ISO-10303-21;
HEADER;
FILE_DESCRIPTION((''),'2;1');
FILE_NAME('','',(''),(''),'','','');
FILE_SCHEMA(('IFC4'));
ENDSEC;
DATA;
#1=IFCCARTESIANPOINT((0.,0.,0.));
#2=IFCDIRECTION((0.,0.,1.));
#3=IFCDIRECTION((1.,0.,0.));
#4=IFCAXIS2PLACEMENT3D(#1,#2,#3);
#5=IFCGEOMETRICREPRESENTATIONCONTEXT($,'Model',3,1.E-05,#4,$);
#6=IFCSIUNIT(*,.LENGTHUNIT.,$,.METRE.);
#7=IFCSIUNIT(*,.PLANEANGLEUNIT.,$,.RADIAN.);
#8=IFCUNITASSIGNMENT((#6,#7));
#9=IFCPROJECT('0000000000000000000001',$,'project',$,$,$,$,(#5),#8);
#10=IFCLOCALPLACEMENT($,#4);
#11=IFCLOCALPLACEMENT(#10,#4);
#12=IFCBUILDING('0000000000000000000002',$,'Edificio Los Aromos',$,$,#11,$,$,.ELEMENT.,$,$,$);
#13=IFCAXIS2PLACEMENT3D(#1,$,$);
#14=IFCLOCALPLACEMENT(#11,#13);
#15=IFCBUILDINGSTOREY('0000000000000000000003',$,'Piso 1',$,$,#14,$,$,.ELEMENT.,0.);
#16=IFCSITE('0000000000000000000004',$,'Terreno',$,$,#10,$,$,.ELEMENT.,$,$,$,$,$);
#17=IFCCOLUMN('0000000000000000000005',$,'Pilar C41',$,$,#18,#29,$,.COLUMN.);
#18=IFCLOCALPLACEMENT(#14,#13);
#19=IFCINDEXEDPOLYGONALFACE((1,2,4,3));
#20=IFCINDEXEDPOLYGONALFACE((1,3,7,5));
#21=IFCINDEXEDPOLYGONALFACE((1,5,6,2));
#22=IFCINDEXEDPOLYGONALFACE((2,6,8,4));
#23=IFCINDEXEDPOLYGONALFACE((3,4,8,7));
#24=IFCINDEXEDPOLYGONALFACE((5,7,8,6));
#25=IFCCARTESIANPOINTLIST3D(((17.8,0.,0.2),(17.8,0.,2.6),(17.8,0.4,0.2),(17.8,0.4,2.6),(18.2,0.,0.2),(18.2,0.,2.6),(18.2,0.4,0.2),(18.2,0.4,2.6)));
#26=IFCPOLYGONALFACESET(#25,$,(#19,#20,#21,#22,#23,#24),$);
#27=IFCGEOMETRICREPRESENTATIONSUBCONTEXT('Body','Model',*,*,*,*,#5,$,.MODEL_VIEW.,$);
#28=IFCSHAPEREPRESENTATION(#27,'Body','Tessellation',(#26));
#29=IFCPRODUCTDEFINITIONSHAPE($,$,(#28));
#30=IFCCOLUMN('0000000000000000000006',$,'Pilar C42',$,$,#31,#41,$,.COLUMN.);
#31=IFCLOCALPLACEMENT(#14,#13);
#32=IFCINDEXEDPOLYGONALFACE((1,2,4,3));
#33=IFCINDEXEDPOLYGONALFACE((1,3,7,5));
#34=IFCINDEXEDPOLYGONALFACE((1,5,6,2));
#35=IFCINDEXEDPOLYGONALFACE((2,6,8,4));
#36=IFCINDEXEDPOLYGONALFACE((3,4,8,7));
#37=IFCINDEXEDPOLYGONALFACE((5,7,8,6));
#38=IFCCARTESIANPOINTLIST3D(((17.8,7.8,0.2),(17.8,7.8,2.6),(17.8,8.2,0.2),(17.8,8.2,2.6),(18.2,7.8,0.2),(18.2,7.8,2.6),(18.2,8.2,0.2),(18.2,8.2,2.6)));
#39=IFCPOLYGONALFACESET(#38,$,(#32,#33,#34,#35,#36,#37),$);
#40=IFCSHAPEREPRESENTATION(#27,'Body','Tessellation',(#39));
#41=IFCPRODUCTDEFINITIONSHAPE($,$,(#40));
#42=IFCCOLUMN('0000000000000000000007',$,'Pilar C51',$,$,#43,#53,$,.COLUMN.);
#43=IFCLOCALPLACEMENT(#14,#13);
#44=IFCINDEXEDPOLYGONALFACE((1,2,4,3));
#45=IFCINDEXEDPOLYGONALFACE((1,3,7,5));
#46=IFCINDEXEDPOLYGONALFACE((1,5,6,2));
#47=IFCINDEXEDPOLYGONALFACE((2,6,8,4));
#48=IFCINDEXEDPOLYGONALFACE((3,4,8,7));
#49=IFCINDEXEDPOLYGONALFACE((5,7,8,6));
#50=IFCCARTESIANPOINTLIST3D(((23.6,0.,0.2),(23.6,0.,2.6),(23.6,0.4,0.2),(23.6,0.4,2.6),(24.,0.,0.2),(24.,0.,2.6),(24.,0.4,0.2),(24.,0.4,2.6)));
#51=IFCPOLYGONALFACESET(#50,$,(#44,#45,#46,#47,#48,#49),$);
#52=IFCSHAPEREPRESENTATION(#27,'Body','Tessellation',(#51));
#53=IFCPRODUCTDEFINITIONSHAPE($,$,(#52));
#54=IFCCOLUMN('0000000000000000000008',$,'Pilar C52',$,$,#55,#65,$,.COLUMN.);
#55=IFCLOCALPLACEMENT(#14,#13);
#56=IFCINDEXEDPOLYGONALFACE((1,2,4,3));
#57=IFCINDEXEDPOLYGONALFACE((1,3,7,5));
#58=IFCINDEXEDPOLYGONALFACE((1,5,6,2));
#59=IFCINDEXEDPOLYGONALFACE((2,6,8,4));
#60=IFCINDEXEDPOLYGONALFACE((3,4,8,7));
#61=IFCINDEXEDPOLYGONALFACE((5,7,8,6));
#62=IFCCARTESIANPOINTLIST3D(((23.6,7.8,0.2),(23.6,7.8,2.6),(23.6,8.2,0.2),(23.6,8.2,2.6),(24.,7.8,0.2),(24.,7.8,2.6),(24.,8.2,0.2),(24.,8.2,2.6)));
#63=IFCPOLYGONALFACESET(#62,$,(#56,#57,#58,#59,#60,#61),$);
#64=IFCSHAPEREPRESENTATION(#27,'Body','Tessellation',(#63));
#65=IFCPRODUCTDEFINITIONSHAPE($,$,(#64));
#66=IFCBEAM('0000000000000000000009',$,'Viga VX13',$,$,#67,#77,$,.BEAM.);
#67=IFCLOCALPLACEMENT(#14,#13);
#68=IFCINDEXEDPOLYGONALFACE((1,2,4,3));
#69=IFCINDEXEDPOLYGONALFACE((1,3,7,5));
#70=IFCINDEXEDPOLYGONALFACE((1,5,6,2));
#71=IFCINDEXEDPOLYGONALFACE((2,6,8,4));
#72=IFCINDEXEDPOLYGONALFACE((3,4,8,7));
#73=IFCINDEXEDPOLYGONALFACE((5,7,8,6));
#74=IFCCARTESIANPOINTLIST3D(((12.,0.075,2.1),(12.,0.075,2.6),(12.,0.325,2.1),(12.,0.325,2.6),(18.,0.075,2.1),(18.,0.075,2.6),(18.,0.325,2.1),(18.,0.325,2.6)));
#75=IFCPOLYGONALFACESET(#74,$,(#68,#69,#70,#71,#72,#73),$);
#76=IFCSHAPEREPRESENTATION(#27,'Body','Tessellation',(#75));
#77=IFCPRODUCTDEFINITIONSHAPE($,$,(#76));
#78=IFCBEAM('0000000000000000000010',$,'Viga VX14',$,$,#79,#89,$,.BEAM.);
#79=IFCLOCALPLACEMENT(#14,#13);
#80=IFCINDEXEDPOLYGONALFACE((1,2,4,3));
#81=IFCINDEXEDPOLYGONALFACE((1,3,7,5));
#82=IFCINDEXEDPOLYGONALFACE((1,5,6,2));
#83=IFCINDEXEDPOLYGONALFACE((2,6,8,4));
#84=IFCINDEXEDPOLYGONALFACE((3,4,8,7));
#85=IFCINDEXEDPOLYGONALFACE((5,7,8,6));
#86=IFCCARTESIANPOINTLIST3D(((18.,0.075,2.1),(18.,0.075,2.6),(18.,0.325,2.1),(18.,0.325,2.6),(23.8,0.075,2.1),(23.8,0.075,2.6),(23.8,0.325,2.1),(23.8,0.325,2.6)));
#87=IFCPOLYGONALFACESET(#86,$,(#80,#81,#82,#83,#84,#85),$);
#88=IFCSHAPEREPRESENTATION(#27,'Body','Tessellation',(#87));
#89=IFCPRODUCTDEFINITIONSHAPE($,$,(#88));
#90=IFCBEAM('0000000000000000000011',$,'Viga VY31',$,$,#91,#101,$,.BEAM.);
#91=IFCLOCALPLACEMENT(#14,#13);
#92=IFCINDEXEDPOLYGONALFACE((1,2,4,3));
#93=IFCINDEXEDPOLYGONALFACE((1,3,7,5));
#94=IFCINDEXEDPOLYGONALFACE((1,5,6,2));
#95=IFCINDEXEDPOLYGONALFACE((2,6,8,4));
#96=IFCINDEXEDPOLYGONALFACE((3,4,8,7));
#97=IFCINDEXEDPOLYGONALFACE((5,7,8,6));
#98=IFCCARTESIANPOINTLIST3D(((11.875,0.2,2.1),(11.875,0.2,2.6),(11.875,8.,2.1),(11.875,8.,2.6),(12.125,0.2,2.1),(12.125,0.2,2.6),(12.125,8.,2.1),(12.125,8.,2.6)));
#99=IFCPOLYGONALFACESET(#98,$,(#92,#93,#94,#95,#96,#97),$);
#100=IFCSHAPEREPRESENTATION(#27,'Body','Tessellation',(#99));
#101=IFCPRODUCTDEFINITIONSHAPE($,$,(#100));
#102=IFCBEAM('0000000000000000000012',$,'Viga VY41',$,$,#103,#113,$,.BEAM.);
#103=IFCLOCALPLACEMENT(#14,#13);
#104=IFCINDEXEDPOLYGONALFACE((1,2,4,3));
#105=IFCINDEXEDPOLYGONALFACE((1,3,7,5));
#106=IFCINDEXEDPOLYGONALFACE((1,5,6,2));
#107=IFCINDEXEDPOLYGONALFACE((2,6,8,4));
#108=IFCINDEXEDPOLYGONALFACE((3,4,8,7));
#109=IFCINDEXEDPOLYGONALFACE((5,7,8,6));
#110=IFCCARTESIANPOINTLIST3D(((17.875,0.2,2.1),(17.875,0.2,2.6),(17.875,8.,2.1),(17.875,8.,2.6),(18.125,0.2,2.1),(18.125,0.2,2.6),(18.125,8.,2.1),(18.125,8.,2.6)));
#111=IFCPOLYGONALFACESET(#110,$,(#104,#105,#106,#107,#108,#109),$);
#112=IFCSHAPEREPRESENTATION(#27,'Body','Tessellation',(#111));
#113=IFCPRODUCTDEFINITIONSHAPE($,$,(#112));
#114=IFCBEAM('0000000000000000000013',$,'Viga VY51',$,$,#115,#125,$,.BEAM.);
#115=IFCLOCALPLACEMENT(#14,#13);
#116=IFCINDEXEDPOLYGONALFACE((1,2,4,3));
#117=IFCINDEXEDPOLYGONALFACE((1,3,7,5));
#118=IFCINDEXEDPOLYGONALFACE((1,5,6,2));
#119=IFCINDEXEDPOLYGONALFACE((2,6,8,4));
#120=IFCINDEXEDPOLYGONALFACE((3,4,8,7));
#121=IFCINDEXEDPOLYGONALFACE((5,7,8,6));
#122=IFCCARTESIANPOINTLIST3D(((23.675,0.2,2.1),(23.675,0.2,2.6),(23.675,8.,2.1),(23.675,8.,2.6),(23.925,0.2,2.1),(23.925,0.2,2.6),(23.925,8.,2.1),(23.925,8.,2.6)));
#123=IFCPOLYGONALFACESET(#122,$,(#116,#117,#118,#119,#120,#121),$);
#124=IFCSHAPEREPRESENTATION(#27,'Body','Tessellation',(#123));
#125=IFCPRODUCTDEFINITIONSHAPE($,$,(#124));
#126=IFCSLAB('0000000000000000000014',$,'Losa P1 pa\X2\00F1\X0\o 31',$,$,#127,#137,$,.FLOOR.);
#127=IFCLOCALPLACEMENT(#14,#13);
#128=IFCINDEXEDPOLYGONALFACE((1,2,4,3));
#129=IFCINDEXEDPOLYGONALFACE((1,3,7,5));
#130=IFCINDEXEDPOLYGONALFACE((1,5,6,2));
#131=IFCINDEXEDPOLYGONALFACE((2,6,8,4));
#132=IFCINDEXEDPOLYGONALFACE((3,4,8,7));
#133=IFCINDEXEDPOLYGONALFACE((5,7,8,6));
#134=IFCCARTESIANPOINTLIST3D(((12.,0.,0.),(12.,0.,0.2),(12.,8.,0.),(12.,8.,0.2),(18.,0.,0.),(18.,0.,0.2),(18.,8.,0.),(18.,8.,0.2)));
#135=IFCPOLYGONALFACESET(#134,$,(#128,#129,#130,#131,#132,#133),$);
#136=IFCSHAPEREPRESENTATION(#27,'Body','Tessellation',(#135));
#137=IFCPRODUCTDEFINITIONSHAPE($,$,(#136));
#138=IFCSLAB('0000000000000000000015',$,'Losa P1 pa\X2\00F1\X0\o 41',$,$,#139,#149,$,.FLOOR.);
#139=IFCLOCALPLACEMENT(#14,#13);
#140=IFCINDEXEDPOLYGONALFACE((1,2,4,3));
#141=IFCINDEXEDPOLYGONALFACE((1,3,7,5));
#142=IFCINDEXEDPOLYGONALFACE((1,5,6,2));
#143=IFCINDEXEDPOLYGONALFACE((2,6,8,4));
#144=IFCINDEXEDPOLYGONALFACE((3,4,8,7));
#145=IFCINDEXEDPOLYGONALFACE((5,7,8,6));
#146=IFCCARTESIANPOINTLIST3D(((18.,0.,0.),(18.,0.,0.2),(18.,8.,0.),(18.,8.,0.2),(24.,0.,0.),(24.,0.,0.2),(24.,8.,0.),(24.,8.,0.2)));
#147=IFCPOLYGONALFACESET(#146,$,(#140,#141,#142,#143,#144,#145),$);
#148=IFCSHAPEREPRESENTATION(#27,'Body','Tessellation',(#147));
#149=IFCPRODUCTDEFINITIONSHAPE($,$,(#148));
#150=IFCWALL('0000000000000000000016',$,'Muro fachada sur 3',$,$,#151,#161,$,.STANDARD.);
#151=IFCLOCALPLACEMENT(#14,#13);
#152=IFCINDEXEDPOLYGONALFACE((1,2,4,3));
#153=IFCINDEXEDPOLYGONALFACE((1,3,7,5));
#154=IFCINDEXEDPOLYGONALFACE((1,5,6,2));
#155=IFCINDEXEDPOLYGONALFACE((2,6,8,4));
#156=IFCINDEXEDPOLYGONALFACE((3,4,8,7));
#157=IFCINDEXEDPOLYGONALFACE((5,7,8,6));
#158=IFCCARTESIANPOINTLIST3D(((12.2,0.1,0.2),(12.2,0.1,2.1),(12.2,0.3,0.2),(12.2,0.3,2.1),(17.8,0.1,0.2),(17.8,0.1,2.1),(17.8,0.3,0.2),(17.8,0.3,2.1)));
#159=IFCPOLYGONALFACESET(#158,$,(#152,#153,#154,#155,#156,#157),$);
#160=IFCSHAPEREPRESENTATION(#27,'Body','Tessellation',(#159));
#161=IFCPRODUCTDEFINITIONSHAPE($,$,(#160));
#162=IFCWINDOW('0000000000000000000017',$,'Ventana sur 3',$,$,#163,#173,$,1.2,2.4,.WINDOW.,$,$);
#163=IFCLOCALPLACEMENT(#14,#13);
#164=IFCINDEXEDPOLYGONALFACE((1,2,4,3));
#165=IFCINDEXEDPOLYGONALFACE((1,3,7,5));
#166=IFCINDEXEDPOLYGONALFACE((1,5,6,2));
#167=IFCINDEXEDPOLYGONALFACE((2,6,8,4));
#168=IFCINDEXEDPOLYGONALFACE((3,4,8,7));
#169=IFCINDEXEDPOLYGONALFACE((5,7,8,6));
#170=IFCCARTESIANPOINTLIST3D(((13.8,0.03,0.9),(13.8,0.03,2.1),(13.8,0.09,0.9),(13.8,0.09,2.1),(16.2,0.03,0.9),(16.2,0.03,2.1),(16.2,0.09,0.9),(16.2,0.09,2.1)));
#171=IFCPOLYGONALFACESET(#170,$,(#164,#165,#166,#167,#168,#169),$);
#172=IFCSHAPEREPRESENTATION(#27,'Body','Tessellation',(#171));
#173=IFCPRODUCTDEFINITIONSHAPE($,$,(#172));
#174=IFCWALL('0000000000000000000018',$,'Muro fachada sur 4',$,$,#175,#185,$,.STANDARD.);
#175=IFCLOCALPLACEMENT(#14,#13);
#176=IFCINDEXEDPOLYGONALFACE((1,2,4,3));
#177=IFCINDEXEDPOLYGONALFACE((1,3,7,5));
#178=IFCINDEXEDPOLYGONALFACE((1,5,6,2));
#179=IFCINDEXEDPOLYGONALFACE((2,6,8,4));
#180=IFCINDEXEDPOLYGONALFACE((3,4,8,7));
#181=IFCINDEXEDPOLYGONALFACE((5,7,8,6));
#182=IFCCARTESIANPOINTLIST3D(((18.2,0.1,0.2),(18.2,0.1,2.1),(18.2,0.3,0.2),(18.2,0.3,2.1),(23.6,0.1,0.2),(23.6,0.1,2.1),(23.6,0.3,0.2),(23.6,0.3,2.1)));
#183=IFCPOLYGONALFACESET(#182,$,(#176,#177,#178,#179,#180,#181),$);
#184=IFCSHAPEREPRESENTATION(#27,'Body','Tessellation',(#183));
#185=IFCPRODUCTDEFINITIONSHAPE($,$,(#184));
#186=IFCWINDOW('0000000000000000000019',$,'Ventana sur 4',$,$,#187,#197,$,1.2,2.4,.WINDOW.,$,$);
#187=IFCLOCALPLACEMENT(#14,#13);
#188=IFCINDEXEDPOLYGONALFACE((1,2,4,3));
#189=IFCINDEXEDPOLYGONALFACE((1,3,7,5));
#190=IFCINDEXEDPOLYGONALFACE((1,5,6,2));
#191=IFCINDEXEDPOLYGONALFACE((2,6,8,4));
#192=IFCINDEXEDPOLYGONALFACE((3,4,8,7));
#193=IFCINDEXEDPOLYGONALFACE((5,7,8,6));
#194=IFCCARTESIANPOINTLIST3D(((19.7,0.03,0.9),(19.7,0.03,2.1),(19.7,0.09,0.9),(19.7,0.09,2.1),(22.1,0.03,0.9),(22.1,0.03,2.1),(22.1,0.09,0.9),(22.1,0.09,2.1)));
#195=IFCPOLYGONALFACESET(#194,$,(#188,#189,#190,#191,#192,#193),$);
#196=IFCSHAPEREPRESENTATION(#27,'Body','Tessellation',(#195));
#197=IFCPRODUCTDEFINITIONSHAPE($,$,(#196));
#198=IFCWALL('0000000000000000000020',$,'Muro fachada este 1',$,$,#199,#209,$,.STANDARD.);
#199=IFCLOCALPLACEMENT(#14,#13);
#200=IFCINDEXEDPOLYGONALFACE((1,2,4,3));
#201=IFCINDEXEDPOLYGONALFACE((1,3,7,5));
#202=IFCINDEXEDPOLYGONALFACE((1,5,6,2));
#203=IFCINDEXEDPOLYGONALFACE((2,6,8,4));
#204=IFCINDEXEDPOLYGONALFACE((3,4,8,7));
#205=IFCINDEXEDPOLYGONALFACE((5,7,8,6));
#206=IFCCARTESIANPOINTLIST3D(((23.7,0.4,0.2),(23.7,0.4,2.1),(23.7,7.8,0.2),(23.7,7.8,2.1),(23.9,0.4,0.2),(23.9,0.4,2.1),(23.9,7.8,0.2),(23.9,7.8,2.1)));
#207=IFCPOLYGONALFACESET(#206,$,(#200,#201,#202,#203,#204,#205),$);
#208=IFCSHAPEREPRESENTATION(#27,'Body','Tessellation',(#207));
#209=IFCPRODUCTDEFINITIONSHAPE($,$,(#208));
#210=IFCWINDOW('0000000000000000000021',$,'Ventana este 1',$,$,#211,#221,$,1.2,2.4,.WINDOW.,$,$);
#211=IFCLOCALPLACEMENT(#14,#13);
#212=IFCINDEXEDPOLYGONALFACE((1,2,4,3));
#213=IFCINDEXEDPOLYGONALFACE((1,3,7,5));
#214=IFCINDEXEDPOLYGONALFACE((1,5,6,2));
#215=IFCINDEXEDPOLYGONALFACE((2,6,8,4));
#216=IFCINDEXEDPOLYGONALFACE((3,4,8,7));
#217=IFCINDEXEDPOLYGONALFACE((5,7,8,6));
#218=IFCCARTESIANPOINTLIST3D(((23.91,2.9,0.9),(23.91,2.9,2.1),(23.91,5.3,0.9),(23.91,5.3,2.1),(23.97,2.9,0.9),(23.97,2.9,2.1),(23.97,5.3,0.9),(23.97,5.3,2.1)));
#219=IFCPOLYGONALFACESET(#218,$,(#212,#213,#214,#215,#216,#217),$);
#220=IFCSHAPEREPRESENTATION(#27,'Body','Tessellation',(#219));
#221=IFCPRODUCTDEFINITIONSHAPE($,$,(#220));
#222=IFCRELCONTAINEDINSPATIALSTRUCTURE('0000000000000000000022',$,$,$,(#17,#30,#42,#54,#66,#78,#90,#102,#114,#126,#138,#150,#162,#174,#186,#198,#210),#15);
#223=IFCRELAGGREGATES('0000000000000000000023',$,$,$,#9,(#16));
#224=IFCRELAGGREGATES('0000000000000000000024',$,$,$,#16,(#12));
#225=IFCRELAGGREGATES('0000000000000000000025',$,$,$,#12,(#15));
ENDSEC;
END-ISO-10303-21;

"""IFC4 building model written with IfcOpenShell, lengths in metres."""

from ifc_helpers import new_model, si_unit, frame, frame_2d, origin, origin_with_axes, place, context, subcontext, project, spatial, rectangle, extrude, element, save


model = new_model("IFC4")

# Units and contexts
model_context = context("Model", 3, precision=1e-05, world=origin_with_axes())
body_context = subcontext(model_context, "Body", "Model", "MODEL_VIEW")
ifc_project = project(units=[si_unit("LENGTHUNIT", "METRE"), si_unit("PLANEANGLEUNIT", "RADIAN")], contexts=[model_context])

# Site, building, storey
site_placement = place(None, origin_with_axes())
site = spatial("IfcSite", under=ifc_project, at=site_placement, Name="Terreno", CompositionType="ELEMENT")
building_placement = place(site_placement, origin_with_axes())
building = spatial("IfcBuilding", under=site, at=building_placement, Name="Edificio Los Aromos", CompositionType="ELEMENT")
storey_placement = place(building_placement, origin())
storey = spatial("IfcBuildingStorey", under=building, at=storey_placement, Name="Piso 1", CompositionType="ELEMENT", Elevation=0.0)

# Columns
for number, where, name in (
    (1, (17.8, 0.0, 0.2), "Pilar C41"),
    (2, (17.8, 7.8, 0.2), "Pilar C42"),
    (3, (23.6, 0.0, 0.2), "Pilar C51"),
    (4, (23.6, 7.8, 0.2), "Pilar C52"),
):
    element("IfcColumn", number, at=place(storey_placement, frame(where)), inside=storey, Name=name, PredefinedType="COLUMN", context=body_context, shape_type="SweptSolid", body=[
        extrude(rectangle(XDim=0.4, YDim=0.4, at=frame_2d((0.2, 0.2))), origin_with_axes(), (0.0, 0.0, 1.0), 2.4),
    ])

# Beams
beam_1_placement = place(storey_placement, frame((12.0, 0.075, 2.1)))
element("IfcBeam", 5, at=beam_1_placement, inside=storey, Name="Viga VX13", PredefinedType="BEAM", context=body_context, shape_type="SweptSolid", body=[
    extrude(rectangle(XDim=6.0, YDim=0.25, at=frame_2d((3.0, 0.125))), origin_with_axes(), (0.0, 0.0, 1.0), 0.5),
])
beam_2_placement = place(storey_placement, frame((18.0, 0.075, 2.1)))
element("IfcBeam", 6, at=beam_2_placement, inside=storey, Name="Viga VX14", PredefinedType="BEAM", context=body_context, shape_type="SweptSolid", body=[
    extrude(rectangle(XDim=5.8, YDim=0.25, at=frame_2d((2.9, 0.125))), origin_with_axes(), (0.0, 0.0, 1.0), 0.5),
])
for number, where, name in (
    (7, (11.875, 0.2, 2.1), "Viga VY31"),
    (8, (17.875, 0.2, 2.1), "Viga VY41"),
    (9, (23.675, 0.2, 2.1), "Viga VY51"),
):
    element("IfcBeam", number, at=place(storey_placement, frame(where)), inside=storey, Name=name, PredefinedType="BEAM", context=body_context, shape_type="SweptSolid", body=[
        extrude(rectangle(XDim=0.25, YDim=7.8, at=frame_2d((0.125, 3.9))), origin_with_axes(), (0.0, 0.0, 1.0), 0.5),
    ])

# Slabs
for number, where, name in (
    (10, (12.0, 0.0, 0.0), "Losa P1 paño 31"),
    (11, (18.0, 0.0, 0.0), "Losa P1 paño 41"),
):
    element("IfcSlab", number, at=place(storey_placement, frame(where)), inside=storey, Name=name, PredefinedType="FLOOR", context=body_context, shape_type="SweptSolid", body=[
        extrude(rectangle(XDim=6.0, YDim=8.0, at=frame_2d((3.0, 4.0))), origin_with_axes(), (0.0, 0.0, 1.0), 0.2),
    ])

# Wall
wall_1_placement = place(storey_placement, frame((12.2, 0.1, 0.2)))
element("IfcWall", 12, at=wall_1_placement, inside=storey, Name="Muro fachada sur 3", PredefinedType="STANDARD", context=body_context, shape_type="SweptSolid", body=[
    extrude(rectangle(XDim=5.6, YDim=0.2, at=frame_2d((2.8, 0.1))), origin_with_axes(), (0.0, 0.0, 1.0), 1.9),
])

# Window
window_1_placement = place(storey_placement, frame((13.8, 0.03, 0.9)))
element("IfcWindow", 13, at=window_1_placement, inside=storey, Name="Ventana sur 3", OverallHeight=1.2, OverallWidth=2.4, PredefinedType="WINDOW", context=body_context, shape_type="SweptSolid", body=[
    extrude(rectangle(XDim=2.4, YDim=0.06, at=frame_2d((1.2, 0.03))), origin_with_axes(), (0.0, 0.0, 1.0), 1.2),
])

# Wall
wall_2_placement = place(storey_placement, frame((18.2, 0.1, 0.2)))
element("IfcWall", 14, at=wall_2_placement, inside=storey, Name="Muro fachada sur 4", PredefinedType="STANDARD", context=body_context, shape_type="SweptSolid", body=[
    extrude(rectangle(XDim=5.4, YDim=0.2, at=frame_2d((2.7, 0.1))), origin_with_axes(), (0.0, 0.0, 1.0), 1.9),
])

# Window
window_2_placement = place(storey_placement, frame((19.7, 0.03, 0.9)))
element("IfcWindow", 15, at=window_2_placement, inside=storey, Name="Ventana sur 4", OverallHeight=1.2, OverallWidth=2.4, PredefinedType="WINDOW", context=body_context, shape_type="SweptSolid", body=[
    extrude(rectangle(XDim=2.4, YDim=0.06, at=frame_2d((1.2, 0.03))), origin_with_axes(), (0.0, 0.0, 1.0), 1.2),
])

# Wall
wall_3_placement = place(storey_placement, frame((23.7, 0.4, 0.2)))
element("IfcWall", 16, at=wall_3_placement, inside=storey, Name="Muro fachada este 1", PredefinedType="STANDARD", context=body_context, shape_type="SweptSolid", body=[
    extrude(rectangle(XDim=0.2, YDim=7.4, at=frame_2d((0.1, 3.7))), origin_with_axes(), (0.0, 0.0, 1.0), 1.9),
])

# Window
window_3_placement = place(storey_placement, frame((23.91, 2.9, 0.9)))
element("IfcWindow", 17, at=window_3_placement, inside=storey, Name="Ventana este 1", OverallHeight=1.2, OverallWidth=2.4, PredefinedType="WINDOW", context=body_context, shape_type="SweptSolid", body=[
    extrude(rectangle(XDim=0.06, YDim=2.4, at=frame_2d((0.03, 1.2))), origin_with_axes(), (0.0, 0.0, 1.0), 1.2),
])

save(model, "model.ifc")
